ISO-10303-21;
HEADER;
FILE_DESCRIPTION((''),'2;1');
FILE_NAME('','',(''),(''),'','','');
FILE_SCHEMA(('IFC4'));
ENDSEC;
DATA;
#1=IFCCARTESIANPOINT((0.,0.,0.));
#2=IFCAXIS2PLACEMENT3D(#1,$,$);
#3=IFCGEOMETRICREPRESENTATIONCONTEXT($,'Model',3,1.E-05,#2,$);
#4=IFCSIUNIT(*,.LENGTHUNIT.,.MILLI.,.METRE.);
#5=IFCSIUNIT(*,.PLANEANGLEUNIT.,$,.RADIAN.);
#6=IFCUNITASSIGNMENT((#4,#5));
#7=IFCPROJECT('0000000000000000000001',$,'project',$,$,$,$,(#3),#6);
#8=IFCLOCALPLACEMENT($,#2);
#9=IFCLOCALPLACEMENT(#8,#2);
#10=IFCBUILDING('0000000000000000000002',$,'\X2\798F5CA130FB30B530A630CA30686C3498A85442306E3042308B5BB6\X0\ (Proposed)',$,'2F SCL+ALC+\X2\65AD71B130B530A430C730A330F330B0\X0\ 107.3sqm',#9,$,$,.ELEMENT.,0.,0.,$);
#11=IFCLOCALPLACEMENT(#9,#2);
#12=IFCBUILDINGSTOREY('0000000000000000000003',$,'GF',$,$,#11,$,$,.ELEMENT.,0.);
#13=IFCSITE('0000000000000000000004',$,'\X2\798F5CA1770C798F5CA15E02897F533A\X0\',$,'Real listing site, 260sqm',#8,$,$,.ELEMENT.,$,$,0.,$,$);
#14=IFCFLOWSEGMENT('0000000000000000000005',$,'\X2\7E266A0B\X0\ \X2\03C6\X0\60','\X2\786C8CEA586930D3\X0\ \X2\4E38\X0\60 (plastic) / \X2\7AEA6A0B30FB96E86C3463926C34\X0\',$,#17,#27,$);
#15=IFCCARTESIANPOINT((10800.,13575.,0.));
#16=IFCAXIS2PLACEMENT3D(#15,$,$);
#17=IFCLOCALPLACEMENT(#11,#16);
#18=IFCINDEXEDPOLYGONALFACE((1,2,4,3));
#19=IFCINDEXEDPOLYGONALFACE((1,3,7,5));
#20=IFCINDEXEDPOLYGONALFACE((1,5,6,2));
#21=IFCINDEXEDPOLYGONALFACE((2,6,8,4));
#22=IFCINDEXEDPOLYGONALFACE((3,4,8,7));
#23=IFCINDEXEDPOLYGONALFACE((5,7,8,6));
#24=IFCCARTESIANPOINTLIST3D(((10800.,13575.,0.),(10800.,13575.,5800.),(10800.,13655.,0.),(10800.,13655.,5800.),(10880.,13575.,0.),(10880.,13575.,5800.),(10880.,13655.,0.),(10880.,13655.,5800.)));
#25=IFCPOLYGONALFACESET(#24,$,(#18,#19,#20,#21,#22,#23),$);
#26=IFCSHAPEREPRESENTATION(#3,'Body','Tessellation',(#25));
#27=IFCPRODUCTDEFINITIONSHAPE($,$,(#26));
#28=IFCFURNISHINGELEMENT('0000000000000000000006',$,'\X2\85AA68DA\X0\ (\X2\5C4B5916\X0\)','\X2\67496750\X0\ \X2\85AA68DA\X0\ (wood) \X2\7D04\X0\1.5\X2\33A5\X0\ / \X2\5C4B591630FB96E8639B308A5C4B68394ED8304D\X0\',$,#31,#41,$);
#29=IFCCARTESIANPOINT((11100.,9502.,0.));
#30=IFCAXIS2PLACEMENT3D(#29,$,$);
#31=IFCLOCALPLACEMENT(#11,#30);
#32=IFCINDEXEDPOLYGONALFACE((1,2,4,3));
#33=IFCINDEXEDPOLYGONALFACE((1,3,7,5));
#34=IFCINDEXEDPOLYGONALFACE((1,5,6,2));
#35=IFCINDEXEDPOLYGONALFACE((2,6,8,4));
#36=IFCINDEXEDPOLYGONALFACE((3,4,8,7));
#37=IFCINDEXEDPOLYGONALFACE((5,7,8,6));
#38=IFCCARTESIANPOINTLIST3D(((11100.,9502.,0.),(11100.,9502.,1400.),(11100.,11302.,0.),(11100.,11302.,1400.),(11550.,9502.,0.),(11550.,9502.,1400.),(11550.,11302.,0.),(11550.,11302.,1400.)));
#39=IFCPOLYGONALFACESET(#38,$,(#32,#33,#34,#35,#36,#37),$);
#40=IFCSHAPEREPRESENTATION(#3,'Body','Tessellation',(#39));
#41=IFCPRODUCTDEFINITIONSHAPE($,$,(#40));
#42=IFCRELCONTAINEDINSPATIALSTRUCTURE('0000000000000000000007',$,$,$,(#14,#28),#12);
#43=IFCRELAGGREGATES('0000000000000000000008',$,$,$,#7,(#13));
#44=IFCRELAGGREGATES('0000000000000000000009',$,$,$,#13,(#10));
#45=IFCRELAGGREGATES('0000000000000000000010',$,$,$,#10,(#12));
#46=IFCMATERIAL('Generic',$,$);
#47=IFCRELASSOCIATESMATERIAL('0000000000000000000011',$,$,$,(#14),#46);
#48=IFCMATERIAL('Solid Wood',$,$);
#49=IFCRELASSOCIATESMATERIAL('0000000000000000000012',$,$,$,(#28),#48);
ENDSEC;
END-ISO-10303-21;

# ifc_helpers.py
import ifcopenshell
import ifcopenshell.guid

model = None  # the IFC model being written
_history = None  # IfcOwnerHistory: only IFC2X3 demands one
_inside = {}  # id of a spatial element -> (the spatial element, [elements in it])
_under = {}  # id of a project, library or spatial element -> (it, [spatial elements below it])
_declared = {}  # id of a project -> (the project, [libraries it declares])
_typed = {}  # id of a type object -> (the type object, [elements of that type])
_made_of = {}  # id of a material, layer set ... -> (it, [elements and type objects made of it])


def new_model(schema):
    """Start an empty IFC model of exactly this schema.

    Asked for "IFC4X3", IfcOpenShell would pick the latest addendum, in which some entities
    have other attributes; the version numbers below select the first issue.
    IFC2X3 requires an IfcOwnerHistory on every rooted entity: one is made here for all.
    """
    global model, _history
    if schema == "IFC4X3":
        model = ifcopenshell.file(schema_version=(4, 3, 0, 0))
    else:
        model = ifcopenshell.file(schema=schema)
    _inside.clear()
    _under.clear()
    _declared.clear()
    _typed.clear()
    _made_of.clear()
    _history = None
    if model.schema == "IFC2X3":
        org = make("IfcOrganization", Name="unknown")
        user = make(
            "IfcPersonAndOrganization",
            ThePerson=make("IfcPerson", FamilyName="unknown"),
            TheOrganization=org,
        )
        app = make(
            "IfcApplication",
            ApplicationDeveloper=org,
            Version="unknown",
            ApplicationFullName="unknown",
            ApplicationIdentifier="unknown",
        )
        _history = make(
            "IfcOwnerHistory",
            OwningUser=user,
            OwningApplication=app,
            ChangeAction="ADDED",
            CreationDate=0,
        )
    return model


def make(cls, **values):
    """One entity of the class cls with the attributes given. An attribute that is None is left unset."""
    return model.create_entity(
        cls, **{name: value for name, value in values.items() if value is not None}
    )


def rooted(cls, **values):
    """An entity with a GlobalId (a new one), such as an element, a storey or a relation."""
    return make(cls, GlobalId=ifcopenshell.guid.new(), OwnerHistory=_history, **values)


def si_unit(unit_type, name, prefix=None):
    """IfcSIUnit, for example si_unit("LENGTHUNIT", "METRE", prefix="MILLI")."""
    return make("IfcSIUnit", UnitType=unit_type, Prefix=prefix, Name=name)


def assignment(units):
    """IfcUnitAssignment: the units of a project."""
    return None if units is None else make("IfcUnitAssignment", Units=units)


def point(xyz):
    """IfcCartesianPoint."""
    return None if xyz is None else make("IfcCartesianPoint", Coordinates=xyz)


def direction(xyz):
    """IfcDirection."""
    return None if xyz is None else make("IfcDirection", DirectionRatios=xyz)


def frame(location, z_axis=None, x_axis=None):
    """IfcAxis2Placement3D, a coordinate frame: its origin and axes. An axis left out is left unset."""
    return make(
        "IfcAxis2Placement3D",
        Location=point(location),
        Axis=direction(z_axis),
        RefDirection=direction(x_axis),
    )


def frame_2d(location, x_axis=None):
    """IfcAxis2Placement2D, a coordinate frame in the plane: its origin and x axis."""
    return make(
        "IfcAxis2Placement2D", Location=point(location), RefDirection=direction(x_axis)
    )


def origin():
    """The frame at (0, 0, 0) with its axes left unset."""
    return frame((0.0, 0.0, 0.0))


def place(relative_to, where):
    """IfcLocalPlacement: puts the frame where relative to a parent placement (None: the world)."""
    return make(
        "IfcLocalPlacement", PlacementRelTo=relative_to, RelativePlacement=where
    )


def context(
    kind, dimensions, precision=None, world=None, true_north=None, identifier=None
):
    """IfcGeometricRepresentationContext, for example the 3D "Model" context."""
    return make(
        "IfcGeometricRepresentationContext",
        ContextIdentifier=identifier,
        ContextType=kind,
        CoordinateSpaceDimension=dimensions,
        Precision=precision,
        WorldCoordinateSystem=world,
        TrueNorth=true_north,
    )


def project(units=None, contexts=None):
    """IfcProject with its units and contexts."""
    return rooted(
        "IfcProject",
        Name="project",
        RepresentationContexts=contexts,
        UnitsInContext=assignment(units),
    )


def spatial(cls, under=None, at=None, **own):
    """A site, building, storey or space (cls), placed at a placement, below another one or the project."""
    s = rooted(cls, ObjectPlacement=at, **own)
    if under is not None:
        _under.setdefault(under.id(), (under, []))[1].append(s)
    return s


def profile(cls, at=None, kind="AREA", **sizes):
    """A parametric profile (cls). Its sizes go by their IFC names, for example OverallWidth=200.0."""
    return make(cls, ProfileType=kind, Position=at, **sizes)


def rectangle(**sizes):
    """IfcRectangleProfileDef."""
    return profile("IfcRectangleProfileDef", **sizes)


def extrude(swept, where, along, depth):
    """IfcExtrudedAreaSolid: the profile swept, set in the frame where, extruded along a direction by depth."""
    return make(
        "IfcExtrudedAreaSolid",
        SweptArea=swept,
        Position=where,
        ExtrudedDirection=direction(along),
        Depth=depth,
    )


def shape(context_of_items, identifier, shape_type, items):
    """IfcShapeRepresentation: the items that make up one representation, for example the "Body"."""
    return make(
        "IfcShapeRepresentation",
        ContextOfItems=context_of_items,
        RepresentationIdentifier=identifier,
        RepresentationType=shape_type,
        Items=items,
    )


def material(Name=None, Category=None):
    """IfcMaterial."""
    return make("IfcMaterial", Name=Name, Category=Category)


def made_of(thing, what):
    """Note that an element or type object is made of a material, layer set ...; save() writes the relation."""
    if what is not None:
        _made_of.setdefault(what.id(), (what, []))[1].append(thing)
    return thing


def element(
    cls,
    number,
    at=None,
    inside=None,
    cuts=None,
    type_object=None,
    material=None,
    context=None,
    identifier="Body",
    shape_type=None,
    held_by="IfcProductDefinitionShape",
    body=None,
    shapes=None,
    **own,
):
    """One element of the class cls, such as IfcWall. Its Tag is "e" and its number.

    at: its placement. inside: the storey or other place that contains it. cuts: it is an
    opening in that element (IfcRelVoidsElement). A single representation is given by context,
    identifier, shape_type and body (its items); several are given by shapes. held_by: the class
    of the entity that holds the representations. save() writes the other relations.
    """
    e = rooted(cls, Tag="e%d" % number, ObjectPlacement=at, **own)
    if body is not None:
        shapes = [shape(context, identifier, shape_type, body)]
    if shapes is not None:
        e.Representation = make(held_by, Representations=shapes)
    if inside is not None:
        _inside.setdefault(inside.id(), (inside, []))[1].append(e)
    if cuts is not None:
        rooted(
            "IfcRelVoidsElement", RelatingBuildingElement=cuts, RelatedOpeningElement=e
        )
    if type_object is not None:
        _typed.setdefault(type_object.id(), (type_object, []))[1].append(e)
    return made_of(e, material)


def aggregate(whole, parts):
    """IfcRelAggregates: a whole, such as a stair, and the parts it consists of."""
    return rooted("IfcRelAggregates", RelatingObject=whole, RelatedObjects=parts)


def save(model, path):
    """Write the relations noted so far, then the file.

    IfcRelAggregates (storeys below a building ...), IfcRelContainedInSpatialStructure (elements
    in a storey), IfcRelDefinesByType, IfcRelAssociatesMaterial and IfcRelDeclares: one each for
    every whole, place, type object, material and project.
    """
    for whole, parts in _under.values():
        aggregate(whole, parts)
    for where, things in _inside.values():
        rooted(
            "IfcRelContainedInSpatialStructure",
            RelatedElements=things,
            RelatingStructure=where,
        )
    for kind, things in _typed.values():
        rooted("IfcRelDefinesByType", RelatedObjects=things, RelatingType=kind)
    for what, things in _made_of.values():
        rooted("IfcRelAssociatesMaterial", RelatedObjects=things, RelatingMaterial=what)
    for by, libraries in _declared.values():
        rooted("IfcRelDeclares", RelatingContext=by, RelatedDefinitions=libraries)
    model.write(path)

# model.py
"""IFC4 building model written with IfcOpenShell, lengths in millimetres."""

from ifc_helpers import new_model, si_unit, frame, frame_2d, origin, place, context, project, spatial, rectangle, extrude, material, element, save


model = new_model("IFC4")

# Units and contexts
model_context = context("Model", 3, precision=1e-05, world=origin())
ifc_project = project(units=[si_unit("LENGTHUNIT", "METRE", prefix="MILLI"), si_unit("PLANEANGLEUNIT", "RADIAN")], contexts=[model_context])

# Site, building, storey
site_placement = place(None, origin())
site = spatial("IfcSite", under=ifc_project, at=site_placement, Name="福岡県福岡市西区", ObjectType="Real listing site, 260sqm", CompositionType="ELEMENT", RefElevation=0.0)
building_placement = place(site_placement, origin())
building = spatial("IfcBuilding", under=site, at=building_placement, Name="福岡・サウナと水風呂のある家 (Proposed)", ObjectType="2F SCL+ALC+断熱サイディング 107.3sqm", CompositionType="ELEMENT", ElevationOfRefHeight=0.0, ElevationOfTerrain=0.0)
storey_placement = place(building_placement, origin())
storey = spatial("IfcBuildingStorey", under=building, at=storey_placement, Name="GF", CompositionType="ELEMENT", Elevation=0.0)

# Shared definitions
ifc_material_1 = material(Name="Solid Wood")

# Flow segment
ifc_material_2 = material(Name="Generic")
flow_segment_placement = place(storey_placement, frame((10800.0, 13575.0, 0.0)))
element("IfcFlowSegment", 1, at=flow_segment_placement, inside=storey, material=ifc_material_2, Name="縦樋 φ60", Description="硬質塩ビ 丸60 (plastic) / 竪樋・雨水排水", context=model_context, shape_type="SweptSolid", body=[
    extrude(rectangle(XDim=80.0, YDim=80.0, at=frame_2d((40.0, 40.0))), frame((10800.0, 13575.0, 0.0)), (0.0, 0.0, 1.0), 5800.0),
])

# Furnishing element
furnishing_placement = place(storey_placement, frame((11100.0, 9502.0, 0.0)))
element("IfcFurnishingElement", 2, at=furnishing_placement, inside=storey, material=ifc_material_1, Name="薪棚 (屋外)", Description="杉材 薪棚 (wood) 約1.5㎥ / 屋外・雨掛り屋根付き", context=model_context, shape_type="SweptSolid", body=[
    extrude(rectangle(XDim=450.0, YDim=1800.0, at=frame_2d((225.0, 900.0))), frame((11100.0, 9502.0, 0.0)), (0.0, 0.0, 1.0), 1400.0),
])

save(model, "model.ifc")
